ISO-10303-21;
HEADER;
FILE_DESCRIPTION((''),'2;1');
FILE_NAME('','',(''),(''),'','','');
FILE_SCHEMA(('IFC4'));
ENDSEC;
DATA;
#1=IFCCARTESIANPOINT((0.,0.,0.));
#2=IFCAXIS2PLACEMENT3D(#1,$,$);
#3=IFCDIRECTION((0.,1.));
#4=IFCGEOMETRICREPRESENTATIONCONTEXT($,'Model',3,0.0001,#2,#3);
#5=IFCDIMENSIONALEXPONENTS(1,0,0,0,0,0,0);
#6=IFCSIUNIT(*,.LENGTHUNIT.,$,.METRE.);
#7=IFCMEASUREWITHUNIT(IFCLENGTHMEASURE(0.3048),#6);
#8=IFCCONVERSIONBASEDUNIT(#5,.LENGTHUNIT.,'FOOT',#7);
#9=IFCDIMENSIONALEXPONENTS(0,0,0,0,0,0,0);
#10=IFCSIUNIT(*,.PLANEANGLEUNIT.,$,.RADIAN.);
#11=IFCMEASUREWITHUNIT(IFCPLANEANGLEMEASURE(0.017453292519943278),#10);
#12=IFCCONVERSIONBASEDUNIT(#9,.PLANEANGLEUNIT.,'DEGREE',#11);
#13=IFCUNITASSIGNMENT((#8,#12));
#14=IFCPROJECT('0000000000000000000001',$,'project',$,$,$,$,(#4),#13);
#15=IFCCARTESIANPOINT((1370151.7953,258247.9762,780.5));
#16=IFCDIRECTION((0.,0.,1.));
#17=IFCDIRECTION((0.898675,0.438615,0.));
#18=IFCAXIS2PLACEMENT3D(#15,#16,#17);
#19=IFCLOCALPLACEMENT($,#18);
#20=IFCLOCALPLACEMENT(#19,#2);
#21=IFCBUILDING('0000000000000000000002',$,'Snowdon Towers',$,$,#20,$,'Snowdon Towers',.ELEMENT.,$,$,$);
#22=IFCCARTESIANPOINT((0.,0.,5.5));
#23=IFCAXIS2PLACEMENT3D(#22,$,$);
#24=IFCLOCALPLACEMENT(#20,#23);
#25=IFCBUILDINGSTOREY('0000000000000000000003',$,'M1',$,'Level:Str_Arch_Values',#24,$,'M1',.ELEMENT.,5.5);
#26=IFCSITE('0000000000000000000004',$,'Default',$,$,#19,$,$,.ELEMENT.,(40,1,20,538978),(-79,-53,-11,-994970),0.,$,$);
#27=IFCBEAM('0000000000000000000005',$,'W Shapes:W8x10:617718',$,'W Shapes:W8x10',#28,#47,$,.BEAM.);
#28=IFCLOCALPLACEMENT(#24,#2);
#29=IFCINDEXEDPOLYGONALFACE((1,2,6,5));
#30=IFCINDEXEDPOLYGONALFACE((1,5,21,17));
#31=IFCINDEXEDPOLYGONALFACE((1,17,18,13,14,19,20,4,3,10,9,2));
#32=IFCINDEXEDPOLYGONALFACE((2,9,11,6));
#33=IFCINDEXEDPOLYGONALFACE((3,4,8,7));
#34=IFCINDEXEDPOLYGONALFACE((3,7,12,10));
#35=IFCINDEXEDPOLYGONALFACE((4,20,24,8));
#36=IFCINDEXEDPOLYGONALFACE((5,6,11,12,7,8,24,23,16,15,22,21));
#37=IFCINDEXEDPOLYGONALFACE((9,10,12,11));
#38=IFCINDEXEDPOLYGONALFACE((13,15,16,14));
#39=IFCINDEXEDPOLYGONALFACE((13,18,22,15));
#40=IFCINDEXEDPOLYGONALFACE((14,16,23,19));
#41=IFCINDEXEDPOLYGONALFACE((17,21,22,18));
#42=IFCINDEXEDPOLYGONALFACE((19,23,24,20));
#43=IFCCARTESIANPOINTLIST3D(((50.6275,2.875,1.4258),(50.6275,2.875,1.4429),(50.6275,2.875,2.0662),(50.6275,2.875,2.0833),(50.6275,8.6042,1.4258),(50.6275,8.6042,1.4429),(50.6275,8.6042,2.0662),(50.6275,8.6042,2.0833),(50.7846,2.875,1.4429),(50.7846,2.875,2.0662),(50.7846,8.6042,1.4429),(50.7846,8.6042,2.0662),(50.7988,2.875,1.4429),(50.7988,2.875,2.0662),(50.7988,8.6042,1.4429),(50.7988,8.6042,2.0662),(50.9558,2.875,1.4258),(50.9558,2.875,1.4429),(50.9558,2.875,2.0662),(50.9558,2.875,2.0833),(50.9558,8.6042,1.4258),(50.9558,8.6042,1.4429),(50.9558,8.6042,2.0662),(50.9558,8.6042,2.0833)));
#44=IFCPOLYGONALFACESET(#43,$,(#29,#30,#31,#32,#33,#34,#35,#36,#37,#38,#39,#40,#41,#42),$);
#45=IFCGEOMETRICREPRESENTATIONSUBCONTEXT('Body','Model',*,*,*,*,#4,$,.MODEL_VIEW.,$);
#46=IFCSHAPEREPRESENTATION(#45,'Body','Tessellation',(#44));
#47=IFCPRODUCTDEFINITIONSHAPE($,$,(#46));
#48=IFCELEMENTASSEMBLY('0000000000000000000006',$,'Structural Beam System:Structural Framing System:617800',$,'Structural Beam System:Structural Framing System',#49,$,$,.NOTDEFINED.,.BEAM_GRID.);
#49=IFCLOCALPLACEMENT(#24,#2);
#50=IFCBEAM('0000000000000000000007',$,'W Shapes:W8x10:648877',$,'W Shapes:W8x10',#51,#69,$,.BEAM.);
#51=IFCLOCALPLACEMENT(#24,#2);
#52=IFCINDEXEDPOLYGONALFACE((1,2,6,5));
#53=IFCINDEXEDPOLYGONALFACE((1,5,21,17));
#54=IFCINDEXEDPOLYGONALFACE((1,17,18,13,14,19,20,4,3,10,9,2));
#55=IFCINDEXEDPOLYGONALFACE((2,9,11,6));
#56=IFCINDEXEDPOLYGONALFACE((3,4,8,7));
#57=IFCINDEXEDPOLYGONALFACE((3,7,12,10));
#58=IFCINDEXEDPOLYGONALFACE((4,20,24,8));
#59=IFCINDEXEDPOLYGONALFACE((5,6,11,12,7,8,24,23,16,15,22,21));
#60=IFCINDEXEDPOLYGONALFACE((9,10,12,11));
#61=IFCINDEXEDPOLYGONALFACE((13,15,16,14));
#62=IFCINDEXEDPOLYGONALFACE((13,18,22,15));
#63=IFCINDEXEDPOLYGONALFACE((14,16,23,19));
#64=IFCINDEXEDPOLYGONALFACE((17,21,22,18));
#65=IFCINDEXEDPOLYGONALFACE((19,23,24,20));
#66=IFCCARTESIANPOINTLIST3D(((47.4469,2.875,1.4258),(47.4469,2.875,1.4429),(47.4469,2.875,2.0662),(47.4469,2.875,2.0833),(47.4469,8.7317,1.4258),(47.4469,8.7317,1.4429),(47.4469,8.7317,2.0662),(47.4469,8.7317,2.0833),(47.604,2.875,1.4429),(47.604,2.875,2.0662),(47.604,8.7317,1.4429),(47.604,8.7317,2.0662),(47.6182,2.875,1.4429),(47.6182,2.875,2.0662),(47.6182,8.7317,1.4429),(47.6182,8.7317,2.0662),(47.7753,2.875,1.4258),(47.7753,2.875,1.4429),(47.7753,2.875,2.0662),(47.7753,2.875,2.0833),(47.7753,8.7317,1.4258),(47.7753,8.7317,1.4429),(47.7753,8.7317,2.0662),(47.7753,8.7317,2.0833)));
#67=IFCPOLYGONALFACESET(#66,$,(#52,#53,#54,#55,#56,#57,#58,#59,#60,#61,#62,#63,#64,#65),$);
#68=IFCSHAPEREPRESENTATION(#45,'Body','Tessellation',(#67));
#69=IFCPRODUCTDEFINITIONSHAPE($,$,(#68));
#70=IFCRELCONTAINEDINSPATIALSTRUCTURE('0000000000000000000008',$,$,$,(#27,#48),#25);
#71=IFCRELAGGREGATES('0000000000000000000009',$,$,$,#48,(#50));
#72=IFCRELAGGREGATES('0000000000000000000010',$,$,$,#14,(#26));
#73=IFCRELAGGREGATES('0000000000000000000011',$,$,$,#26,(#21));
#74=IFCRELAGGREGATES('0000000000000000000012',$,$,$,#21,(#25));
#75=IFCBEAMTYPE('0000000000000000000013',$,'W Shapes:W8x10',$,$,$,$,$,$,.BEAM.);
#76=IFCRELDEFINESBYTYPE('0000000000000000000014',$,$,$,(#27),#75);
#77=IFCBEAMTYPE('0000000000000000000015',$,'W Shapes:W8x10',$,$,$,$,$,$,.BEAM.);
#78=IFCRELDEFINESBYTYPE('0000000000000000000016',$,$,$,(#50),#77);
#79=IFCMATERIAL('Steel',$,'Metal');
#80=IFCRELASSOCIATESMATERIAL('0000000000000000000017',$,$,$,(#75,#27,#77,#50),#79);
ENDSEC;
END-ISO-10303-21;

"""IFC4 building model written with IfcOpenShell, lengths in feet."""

from ifc_helpers import new_model, entity, si_unit, converted_unit, direction, frame, origin, place, context, subcontext, project, spatial, indexed_curve, outline, extrude, source, transform, mapped, material, type_object, type_shapes, element, aggregate, save


model = new_model("IFC4")

# Units and contexts
model_context = context("Model", 3, precision=0.0001, world=origin(), true_north=direction((0.0, 1.0)))
body_context = subcontext(model_context, "Body", "Model", "MODEL_VIEW")
ifc_project = project(units=[converted_unit("LENGTHUNIT", "FOOT", entity("IfcLengthMeasure", 0.3048), si_unit("LENGTHUNIT", "METRE"), dimensions=[1, 0, 0, 0, 0, 0, 0]), converted_unit("PLANEANGLEUNIT", "DEGREE", entity("IfcPlaneAngleMeasure", 0.017453292519943278), si_unit("PLANEANGLEUNIT", "RADIAN"), dimensions=[0, 0, 0, 0, 0, 0, 0])], contexts=[model_context])

# Site, building, storey
site_placement = place(None, frame((1370151.7953, 258247.9762, 780.5), z_axis=(0.0, 0.0, 1.0), x_axis=(0.898675, 0.438615, 0.0)))
site = spatial("IfcSite", under=ifc_project, at=site_placement, Name="Default", CompositionType="ELEMENT", RefLatitude=(40, 1, 20, 538978), RefLongitude=(-79, -53, -11, -994970), RefElevation=0.0)
building_placement = place(site_placement, origin())
building = spatial("IfcBuilding", under=site, at=building_placement, Name="Snowdon Towers", LongName="Snowdon Towers", CompositionType="ELEMENT")
storey_placement = place(building_placement, frame((0.0, 0.0, 5.5)))
storey = spatial("IfcBuildingStorey", under=building, at=storey_placement, Name="M1", ObjectType="Level:Str_Arch_Values", LongName="M1", CompositionType="ELEMENT", Elevation=5.5)

# Shared definitions
ifc_material = material(Name="Steel", Category="Metal")

# Beam
beam_type_1 = type_object("IfcBeamType", Name="W Shapes:W8x10", PredefinedType="BEAM", material=ifc_material)
shared_shape_1 = source(origin(), body_context, "Body", "SweptSolid", [
    extrude(outline(indexed_curve([(-0.1642, -0.3117), (-0.1642, -0.3288), (0.1642, -0.3288), (0.1642, -0.3117), (0.0071, -0.3117), (0.0071, 0.3117), (0.1642, 0.3117), (0.1642, 0.3287), (-0.1642, 0.3287), (-0.1642, 0.3117), (-0.0071, 0.3117), (-0.0071, -0.3117), (-0.1642, -0.3117)], self_intersect=False)), frame((-2.9167, 0.0, 0.0), z_axis=(-1.0, 0.0, 0.0), x_axis=(0.0, -1.0, 0.0)), (0.0, 0.0, -1.0), 5.7292),
])
type_shapes(beam_type_1, [shared_shape_1])
beam_1_placement = place(storey_placement, frame((50.7917, 5.6875, 1.7546), z_axis=(0.0, 0.0, 1.0), x_axis=(0.0, -1.0, 0.0)))
element("IfcBeam", 1, at=beam_1_placement, inside=storey, type_object=beam_type_1, material=ifc_material, Name="W Shapes:W8x10:617718", ObjectType="W Shapes:W8x10", PredefinedType="BEAM", context=body_context, shape_type="MappedRepresentation", body=[
    mapped(shared_shape_1, transform((0.0, 0.0, 0.0), scale=1.0)),
])

# Element assembly, beam
assembly_1_placement = place(storey_placement, origin())
assembly_1 = element("IfcElementAssembly", 2, at=assembly_1_placement, inside=storey, Name="Structural Beam System:Structural Framing System:617800", ObjectType="Structural Beam System:Structural Framing System", AssemblyPlace="NOTDEFINED", PredefinedType="BEAM_GRID")
beam_type_2 = type_object("IfcBeamType", Name="W Shapes:W8x10", PredefinedType="BEAM", material=ifc_material)
shared_shape_2 = source(origin(), body_context, "Body", "SweptSolid", [
    extrude(outline(indexed_curve([(-0.1642, -0.3117), (-0.1642, -0.3288), (0.1642, -0.3288), (0.1642, -0.3117), (0.0071, -0.3117), (0.0071, 0.3117), (0.1642, 0.3117), (0.1642, 0.3287), (-0.1642, 0.3287), (-0.1642, 0.3117), (-0.0071, 0.3117), (-0.0071, -0.3117), (-0.1642, -0.3117)], self_intersect=False)), frame((-3.0962, 0.0, 0.0), z_axis=(-1.0, 0.0, 0.0), x_axis=(0.0, -1.0, 0.0)), (0.0, 0.0, -1.0), 5.8567),
])
type_shapes(beam_type_2, [shared_shape_2])
beam_2_placement = place(assembly_1_placement, frame((47.6111, 5.6354, 1.7546), z_axis=(0.0, 0.0, 1.0), x_axis=(0.0, -1.0, 0.0)))
beam_2 = element("IfcBeam", 3, at=beam_2_placement, type_object=beam_type_2, material=ifc_material, Name="W Shapes:W8x10:648877", ObjectType="W Shapes:W8x10", PredefinedType="BEAM", context=body_context, shape_type="MappedRepresentation", body=[
    mapped(shared_shape_2, transform((0.0, 0.0, 0.0), scale=1.0)),
])
aggregate(assembly_1, [beam_2])

save(model, "model.ifc")
